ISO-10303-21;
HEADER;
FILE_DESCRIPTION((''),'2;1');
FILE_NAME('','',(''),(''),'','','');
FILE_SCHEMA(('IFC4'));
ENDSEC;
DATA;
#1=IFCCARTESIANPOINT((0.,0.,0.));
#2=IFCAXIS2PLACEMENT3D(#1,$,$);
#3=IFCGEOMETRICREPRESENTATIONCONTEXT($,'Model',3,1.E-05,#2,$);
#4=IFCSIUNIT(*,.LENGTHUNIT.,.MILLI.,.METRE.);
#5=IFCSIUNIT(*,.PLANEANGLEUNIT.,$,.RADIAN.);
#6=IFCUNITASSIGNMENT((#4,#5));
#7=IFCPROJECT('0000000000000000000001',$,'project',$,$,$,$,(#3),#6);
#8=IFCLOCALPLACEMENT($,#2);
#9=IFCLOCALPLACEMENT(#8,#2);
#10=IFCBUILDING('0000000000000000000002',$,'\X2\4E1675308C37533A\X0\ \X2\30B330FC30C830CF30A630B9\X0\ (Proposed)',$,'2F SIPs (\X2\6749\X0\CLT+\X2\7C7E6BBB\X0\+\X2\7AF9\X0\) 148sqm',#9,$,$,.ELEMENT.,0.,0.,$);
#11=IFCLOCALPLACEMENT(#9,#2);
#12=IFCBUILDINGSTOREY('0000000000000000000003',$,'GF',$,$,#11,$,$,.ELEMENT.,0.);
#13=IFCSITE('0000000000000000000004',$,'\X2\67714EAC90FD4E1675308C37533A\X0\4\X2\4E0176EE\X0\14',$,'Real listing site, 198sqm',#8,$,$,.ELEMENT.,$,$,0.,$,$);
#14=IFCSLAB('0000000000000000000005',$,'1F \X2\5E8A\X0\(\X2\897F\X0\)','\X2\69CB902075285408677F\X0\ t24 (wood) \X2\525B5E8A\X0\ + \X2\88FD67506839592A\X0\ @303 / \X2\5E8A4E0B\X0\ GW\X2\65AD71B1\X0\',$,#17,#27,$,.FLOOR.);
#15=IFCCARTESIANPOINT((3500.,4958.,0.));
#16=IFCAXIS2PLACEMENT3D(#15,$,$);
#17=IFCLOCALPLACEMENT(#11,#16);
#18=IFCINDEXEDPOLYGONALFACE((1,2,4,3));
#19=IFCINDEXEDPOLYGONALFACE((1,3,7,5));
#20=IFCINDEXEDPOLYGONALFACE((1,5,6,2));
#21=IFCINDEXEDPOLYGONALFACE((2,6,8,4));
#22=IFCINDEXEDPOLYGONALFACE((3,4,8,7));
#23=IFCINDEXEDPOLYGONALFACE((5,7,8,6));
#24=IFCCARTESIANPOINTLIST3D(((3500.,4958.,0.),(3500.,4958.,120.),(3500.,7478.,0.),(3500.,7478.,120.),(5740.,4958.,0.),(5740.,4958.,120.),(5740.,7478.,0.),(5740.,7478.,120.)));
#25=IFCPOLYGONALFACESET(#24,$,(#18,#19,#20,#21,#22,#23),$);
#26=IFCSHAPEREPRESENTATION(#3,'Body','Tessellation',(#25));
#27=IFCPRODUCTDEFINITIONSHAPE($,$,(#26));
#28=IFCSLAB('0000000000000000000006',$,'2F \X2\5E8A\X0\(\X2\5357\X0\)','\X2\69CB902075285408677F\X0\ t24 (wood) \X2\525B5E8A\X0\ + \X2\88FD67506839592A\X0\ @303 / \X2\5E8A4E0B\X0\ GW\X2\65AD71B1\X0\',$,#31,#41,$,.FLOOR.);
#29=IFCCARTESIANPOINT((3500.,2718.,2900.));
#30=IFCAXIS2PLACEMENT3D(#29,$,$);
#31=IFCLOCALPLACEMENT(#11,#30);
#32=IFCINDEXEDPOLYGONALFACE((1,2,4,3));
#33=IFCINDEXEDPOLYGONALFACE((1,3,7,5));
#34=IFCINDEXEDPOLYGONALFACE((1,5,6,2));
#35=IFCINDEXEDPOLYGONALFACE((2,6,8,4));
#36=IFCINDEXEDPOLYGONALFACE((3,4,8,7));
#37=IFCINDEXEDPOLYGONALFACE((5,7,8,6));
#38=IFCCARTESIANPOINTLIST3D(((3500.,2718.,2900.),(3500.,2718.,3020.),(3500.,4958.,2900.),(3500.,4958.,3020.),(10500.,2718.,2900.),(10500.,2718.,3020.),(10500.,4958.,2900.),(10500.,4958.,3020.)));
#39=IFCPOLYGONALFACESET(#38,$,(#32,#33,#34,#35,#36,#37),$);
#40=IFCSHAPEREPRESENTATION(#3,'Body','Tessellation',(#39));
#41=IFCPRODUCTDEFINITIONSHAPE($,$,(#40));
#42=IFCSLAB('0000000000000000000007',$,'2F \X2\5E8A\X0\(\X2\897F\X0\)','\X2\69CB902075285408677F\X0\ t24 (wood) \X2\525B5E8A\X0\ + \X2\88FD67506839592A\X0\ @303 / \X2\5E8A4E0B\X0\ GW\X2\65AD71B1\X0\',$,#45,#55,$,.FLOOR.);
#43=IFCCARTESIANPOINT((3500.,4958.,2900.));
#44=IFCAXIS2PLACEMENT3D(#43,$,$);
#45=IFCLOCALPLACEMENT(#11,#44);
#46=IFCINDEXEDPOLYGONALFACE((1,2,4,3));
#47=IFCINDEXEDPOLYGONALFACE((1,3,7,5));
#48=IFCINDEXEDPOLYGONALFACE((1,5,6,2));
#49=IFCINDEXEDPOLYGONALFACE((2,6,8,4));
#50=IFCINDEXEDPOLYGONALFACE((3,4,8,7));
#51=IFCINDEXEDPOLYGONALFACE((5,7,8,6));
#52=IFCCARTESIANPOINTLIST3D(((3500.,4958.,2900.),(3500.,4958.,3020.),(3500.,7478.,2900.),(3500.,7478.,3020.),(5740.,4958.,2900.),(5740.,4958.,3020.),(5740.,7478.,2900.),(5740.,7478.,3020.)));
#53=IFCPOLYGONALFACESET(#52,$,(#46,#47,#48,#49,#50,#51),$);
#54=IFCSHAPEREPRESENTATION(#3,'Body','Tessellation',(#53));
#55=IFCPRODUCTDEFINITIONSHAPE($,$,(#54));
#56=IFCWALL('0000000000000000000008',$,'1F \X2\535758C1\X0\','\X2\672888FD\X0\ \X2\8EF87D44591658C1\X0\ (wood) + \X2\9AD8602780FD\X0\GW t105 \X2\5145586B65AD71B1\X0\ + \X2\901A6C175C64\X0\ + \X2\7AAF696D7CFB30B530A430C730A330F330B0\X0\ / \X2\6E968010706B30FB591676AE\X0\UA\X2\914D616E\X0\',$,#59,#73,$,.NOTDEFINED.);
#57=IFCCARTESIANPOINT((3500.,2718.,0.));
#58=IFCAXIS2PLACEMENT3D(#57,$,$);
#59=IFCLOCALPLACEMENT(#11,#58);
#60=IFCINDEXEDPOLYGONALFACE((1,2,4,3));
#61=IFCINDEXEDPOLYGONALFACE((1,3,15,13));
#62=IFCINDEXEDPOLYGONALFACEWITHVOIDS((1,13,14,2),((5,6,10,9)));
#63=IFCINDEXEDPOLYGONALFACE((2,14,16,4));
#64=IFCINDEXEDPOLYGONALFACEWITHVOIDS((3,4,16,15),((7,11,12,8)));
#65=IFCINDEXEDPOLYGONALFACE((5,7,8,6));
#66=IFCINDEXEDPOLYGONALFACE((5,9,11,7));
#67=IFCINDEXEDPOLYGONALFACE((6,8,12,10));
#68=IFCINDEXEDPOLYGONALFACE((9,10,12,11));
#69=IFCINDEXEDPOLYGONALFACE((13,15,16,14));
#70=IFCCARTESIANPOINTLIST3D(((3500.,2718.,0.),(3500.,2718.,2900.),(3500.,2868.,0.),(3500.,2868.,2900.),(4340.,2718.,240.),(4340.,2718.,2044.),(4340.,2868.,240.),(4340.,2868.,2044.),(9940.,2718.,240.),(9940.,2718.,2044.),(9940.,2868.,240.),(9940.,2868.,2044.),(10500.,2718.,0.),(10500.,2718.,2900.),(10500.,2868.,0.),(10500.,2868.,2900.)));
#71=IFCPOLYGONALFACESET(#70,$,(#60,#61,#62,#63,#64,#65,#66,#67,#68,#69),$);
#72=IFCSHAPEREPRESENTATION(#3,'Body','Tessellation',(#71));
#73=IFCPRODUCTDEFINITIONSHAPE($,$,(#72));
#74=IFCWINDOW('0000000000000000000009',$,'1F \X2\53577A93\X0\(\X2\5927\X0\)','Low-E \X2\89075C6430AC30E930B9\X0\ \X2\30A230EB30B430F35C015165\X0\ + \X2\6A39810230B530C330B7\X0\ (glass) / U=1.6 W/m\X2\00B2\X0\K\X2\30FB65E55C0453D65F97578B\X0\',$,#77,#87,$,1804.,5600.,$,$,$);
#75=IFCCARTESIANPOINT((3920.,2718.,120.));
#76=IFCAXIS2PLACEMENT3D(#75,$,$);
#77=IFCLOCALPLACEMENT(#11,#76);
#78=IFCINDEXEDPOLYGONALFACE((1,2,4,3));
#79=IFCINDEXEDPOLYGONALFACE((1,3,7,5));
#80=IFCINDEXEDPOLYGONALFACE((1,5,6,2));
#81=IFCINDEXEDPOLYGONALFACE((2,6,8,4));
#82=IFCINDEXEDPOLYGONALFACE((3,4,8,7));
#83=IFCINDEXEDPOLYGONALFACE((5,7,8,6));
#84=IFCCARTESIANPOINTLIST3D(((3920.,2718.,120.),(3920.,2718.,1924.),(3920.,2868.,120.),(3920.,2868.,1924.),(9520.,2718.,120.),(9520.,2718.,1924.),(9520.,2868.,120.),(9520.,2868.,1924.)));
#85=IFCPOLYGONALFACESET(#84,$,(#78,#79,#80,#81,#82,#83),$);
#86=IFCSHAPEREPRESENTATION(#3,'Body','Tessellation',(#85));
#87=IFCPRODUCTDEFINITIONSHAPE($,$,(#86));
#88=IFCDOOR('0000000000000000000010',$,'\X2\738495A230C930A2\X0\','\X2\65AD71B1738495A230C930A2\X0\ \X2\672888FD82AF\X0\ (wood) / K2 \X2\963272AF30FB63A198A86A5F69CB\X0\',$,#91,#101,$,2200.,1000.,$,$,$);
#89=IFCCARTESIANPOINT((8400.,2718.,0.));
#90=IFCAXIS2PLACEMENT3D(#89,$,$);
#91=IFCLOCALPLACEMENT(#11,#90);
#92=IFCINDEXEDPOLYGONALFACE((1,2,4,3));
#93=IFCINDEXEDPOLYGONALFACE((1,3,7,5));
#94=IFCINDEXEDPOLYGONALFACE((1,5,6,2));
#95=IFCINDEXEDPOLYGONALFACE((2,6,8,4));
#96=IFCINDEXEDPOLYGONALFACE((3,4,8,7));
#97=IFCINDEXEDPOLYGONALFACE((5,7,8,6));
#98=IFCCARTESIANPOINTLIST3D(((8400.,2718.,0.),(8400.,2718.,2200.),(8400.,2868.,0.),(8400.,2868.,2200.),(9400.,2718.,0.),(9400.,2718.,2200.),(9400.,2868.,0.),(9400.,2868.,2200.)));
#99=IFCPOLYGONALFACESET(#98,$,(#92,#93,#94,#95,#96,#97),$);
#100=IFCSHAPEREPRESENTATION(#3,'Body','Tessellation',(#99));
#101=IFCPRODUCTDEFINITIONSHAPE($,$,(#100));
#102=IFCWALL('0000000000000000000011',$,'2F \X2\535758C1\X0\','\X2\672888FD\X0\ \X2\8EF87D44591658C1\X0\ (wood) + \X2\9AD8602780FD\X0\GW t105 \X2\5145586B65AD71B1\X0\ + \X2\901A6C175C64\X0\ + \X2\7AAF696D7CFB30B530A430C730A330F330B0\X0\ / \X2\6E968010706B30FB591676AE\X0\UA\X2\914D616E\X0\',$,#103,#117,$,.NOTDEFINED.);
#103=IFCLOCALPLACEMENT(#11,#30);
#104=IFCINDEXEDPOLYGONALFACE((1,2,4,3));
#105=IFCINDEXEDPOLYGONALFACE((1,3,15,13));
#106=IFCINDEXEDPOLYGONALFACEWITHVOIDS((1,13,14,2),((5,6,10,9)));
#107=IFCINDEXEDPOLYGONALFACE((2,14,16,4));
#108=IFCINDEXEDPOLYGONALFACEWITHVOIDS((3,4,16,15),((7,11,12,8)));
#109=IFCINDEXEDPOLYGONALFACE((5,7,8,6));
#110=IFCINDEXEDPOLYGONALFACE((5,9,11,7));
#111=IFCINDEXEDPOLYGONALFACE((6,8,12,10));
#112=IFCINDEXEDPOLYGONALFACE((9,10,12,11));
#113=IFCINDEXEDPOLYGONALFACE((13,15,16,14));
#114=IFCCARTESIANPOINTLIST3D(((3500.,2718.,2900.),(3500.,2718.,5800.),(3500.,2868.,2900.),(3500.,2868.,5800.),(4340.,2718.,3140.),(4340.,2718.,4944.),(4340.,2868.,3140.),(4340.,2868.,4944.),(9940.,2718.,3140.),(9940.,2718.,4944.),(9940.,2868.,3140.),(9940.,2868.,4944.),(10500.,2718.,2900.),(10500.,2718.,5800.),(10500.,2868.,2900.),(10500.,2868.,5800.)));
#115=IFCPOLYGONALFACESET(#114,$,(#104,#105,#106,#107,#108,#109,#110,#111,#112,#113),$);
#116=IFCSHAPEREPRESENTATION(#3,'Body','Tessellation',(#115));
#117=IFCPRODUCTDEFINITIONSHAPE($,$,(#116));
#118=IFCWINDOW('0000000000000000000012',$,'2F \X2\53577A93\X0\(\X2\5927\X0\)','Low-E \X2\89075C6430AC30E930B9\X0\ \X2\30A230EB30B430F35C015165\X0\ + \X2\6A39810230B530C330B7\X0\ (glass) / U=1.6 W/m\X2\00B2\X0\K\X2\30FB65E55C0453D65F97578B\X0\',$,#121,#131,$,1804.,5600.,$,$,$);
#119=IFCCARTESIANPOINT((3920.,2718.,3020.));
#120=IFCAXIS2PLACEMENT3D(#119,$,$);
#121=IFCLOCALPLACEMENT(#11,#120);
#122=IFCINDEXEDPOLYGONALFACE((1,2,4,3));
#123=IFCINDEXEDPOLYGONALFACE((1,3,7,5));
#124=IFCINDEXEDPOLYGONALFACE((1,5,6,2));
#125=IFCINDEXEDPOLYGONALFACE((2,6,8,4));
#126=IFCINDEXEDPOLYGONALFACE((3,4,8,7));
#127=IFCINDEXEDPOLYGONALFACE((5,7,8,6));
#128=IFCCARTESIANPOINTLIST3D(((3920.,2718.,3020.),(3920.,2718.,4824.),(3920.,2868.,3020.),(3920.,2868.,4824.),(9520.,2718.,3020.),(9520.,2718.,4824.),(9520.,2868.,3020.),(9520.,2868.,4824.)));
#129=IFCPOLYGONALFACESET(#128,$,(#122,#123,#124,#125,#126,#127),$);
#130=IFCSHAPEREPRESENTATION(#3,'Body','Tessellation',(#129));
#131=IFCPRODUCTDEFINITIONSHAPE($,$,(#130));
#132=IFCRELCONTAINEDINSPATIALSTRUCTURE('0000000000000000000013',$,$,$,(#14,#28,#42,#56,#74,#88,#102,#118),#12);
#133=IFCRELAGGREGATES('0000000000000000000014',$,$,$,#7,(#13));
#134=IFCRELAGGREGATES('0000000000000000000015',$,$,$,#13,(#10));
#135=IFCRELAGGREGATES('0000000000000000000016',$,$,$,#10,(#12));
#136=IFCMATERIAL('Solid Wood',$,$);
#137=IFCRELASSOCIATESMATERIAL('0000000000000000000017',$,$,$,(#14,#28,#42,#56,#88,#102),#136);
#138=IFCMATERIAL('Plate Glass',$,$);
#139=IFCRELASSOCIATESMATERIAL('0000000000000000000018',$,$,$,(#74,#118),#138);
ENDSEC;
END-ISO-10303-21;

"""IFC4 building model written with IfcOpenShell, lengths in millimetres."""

from ifc_helpers import new_model, si_unit, frame, frame_2d, origin, place, context, project, spatial, rectangle, extrude, material, element, fill, save


model = new_model("IFC4")

# Units and contexts
model_context = context("Model", 3, precision=1e-05, world=origin())
ifc_project = project(units=[si_unit("LENGTHUNIT", "METRE", prefix="MILLI"), si_unit("PLANEANGLEUNIT", "RADIAN")], contexts=[model_context])

# Site, building, storey
site_placement = place(None, origin())
site = spatial("IfcSite", under=ifc_project, at=site_placement, Name="東京都世田谷区4丁目14", ObjectType="Real listing site, 198sqm", CompositionType="ELEMENT", RefElevation=0.0)
building_placement = place(site_placement, origin())
building = spatial("IfcBuilding", under=site, at=building_placement, Name="世田谷区 コートハウス (Proposed)", ObjectType="2F SIPs (杉CLT+籾殻+竹) 148sqm", CompositionType="ELEMENT", ElevationOfRefHeight=0.0, ElevationOfTerrain=0.0)
storey_placement = place(building_placement, origin())
storey = spatial("IfcBuildingStorey", under=building, at=storey_placement, Name="GF", CompositionType="ELEMENT", Elevation=0.0)

# Slabs
ifc_material_1 = material(Name="Solid Wood")
slab_1_placement = place(storey_placement, frame((3500.0, 4958.0, 0.0)))
element("IfcSlab", 1, at=slab_1_placement, inside=storey, material=ifc_material_1, Name="1F 床(西)", Description="構造用合板 t24 (wood) 剛床 + 製材根太 @303 / 床下 GW断熱", PredefinedType="FLOOR", context=model_context, shape_type="SweptSolid", body=[
    extrude(rectangle(XDim=2240.0, YDim=2520.0, at=frame_2d((1120.0, 1260.0))), frame((3500.0, 4958.0, 0.0)), (0.0, 0.0, 1.0), 120.0),
])
slab_2_placement = place(storey_placement, frame((3500.0, 2718.0, 2900.0)))
element("IfcSlab", 2, at=slab_2_placement, inside=storey, material=ifc_material_1, Name="2F 床(南)", Description="構造用合板 t24 (wood) 剛床 + 製材根太 @303 / 床下 GW断熱", PredefinedType="FLOOR", context=model_context, shape_type="SweptSolid", body=[
    extrude(rectangle(XDim=7000.0, YDim=2240.0, at=frame_2d((3500.0, 1120.0))), frame((3500.0, 2718.0, 2900.0)), (0.0, 0.0, 1.0), 120.0),
])
slab_3_placement = place(storey_placement, frame((3500.0, 4958.0, 2900.0)))
element("IfcSlab", 3, at=slab_3_placement, inside=storey, material=ifc_material_1, Name="2F 床(西)", Description="構造用合板 t24 (wood) 剛床 + 製材根太 @303 / 床下 GW断熱", PredefinedType="FLOOR", context=model_context, shape_type="SweptSolid", body=[
    extrude(rectangle(XDim=2240.0, YDim=2520.0, at=frame_2d((1120.0, 1260.0))), frame((3500.0, 4958.0, 2900.0)), (0.0, 0.0, 1.0), 120.0),
])

# Wall, openings, window, door
wall_1_placement = place(storey_placement, frame((3500.0, 2718.0, 0.0)))
wall_1 = element("IfcWall", 4, at=wall_1_placement, inside=storey, material=ifc_material_1, Name="1F 南壁", Description="木製 軸組外壁 (wood) + 高性能GW t105 充填断熱 + 通気層 + 窯業系サイディング / 準耐火・外皮UA配慮", PredefinedType="NOTDEFINED", context=model_context, shape_type="SweptSolid", body=[
    extrude(rectangle(XDim=7000.0, YDim=150.0, at=frame_2d((3500.0, 75.0))), frame((3500.0, 2718.0, 0.0)), (0.0, 0.0, 1.0), 2900.0),
])
opening_1_placement = place(storey_placement, frame((3920.0, 2718.0, 120.0)))
opening_1 = element("IfcOpeningElement", 5, at=opening_1_placement, cuts=wall_1, PredefinedType="NOTDEFINED", context=model_context, shape_type="SweptSolid", body=[
    extrude(rectangle(XDim=5600.0, YDim=150.0, at=frame_2d((2800.0, 75.0))), frame((3920.0, 2718.0, 120.0)), (0.0, 0.0, 1.0), 1804.0),
])
opening_2_placement = place(storey_placement, frame((8400.0, 2718.0, 0.0)))
opening_2 = element("IfcOpeningElement", 6, at=opening_2_placement, cuts=wall_1, PredefinedType="NOTDEFINED", context=model_context, shape_type="SweptSolid", body=[
    extrude(rectangle(XDim=1000.0, YDim=150.0, at=frame_2d((500.0, 75.0))), frame((8400.0, 2718.0, 0.0)), (0.0, 0.0, 1.0), 2200.0),
])
ifc_material_2 = material(Name="Plate Glass")
window_1_placement = place(storey_placement, frame((3920.0, 2718.0, 120.0)))
window_1 = element("IfcWindow", 7, at=window_1_placement, inside=storey, material=ifc_material_2, Name="1F 南窓(大)", Description="Low-E 複層ガラス アルゴン封入 + 樹脂サッシ (glass) / U=1.6 W/m²K・日射取得型", OverallHeight=1804.0, OverallWidth=5600.0, context=model_context, shape_type="SweptSolid", body=[
    extrude(rectangle(XDim=5600.0, YDim=150.0, at=frame_2d((2800.0, 75.0))), frame((3920.0, 2718.0, 120.0)), (0.0, 0.0, 1.0), 1804.0),
])
fill(opening_1, window_1)
door_placement = place(storey_placement, frame((8400.0, 2718.0, 0.0)))
door = element("IfcDoor", 8, at=door_placement, inside=storey, material=ifc_material_1, Name="玄関ドア", Description="断熱玄関ドア 木製芯 (wood) / K2 防犯・採風機構", OverallHeight=2200.0, OverallWidth=1000.0, context=model_context, shape_type="SweptSolid", body=[
    extrude(rectangle(XDim=1000.0, YDim=150.0, at=frame_2d((500.0, 75.0))), frame((8400.0, 2718.0, 0.0)), (0.0, 0.0, 1.0), 2200.0),
])
fill(opening_2, door)

# Wall, opening, window
wall_2_placement = place(storey_placement, frame((3500.0, 2718.0, 2900.0)))
wall_2 = element("IfcWall", 9, at=wall_2_placement, inside=storey, material=ifc_material_1, Name="2F 南壁", Description="木製 軸組外壁 (wood) + 高性能GW t105 充填断熱 + 通気層 + 窯業系サイディング / 準耐火・外皮UA配慮", PredefinedType="NOTDEFINED", context=model_context, shape_type="SweptSolid", body=[
    extrude(rectangle(XDim=7000.0, YDim=150.0, at=frame_2d((3500.0, 75.0))), frame((3500.0, 2718.0, 2900.0)), (0.0, 0.0, 1.0), 2900.0),
])
opening_3_placement = place(storey_placement, frame((3920.0, 2718.0, 3020.0)))
opening_3 = element("IfcOpeningElement", 10, at=opening_3_placement, cuts=wall_2, PredefinedType="NOTDEFINED", context=model_context, shape_type="SweptSolid", body=[
    extrude(rectangle(XDim=5600.0, YDim=150.0, at=frame_2d((2800.0, 75.0))), frame((3920.0, 2718.0, 3020.0)), (0.0, 0.0, 1.0), 1804.0),
])
window_2_placement = place(storey_placement, frame((3920.0, 2718.0, 3020.0)))
window_2 = element("IfcWindow", 11, at=window_2_placement, inside=storey, material=ifc_material_2, Name="2F 南窓(大)", Description="Low-E 複層ガラス アルゴン封入 + 樹脂サッシ (glass) / U=1.6 W/m²K・日射取得型", OverallHeight=1804.0, OverallWidth=5600.0, context=model_context, shape_type="SweptSolid", body=[
    extrude(rectangle(XDim=5600.0, YDim=150.0, at=frame_2d((2800.0, 75.0))), frame((3920.0, 2718.0, 3020.0)), (0.0, 0.0, 1.0), 1804.0),
])
fill(opening_3, window_2)

save(model, "model.ifc")
